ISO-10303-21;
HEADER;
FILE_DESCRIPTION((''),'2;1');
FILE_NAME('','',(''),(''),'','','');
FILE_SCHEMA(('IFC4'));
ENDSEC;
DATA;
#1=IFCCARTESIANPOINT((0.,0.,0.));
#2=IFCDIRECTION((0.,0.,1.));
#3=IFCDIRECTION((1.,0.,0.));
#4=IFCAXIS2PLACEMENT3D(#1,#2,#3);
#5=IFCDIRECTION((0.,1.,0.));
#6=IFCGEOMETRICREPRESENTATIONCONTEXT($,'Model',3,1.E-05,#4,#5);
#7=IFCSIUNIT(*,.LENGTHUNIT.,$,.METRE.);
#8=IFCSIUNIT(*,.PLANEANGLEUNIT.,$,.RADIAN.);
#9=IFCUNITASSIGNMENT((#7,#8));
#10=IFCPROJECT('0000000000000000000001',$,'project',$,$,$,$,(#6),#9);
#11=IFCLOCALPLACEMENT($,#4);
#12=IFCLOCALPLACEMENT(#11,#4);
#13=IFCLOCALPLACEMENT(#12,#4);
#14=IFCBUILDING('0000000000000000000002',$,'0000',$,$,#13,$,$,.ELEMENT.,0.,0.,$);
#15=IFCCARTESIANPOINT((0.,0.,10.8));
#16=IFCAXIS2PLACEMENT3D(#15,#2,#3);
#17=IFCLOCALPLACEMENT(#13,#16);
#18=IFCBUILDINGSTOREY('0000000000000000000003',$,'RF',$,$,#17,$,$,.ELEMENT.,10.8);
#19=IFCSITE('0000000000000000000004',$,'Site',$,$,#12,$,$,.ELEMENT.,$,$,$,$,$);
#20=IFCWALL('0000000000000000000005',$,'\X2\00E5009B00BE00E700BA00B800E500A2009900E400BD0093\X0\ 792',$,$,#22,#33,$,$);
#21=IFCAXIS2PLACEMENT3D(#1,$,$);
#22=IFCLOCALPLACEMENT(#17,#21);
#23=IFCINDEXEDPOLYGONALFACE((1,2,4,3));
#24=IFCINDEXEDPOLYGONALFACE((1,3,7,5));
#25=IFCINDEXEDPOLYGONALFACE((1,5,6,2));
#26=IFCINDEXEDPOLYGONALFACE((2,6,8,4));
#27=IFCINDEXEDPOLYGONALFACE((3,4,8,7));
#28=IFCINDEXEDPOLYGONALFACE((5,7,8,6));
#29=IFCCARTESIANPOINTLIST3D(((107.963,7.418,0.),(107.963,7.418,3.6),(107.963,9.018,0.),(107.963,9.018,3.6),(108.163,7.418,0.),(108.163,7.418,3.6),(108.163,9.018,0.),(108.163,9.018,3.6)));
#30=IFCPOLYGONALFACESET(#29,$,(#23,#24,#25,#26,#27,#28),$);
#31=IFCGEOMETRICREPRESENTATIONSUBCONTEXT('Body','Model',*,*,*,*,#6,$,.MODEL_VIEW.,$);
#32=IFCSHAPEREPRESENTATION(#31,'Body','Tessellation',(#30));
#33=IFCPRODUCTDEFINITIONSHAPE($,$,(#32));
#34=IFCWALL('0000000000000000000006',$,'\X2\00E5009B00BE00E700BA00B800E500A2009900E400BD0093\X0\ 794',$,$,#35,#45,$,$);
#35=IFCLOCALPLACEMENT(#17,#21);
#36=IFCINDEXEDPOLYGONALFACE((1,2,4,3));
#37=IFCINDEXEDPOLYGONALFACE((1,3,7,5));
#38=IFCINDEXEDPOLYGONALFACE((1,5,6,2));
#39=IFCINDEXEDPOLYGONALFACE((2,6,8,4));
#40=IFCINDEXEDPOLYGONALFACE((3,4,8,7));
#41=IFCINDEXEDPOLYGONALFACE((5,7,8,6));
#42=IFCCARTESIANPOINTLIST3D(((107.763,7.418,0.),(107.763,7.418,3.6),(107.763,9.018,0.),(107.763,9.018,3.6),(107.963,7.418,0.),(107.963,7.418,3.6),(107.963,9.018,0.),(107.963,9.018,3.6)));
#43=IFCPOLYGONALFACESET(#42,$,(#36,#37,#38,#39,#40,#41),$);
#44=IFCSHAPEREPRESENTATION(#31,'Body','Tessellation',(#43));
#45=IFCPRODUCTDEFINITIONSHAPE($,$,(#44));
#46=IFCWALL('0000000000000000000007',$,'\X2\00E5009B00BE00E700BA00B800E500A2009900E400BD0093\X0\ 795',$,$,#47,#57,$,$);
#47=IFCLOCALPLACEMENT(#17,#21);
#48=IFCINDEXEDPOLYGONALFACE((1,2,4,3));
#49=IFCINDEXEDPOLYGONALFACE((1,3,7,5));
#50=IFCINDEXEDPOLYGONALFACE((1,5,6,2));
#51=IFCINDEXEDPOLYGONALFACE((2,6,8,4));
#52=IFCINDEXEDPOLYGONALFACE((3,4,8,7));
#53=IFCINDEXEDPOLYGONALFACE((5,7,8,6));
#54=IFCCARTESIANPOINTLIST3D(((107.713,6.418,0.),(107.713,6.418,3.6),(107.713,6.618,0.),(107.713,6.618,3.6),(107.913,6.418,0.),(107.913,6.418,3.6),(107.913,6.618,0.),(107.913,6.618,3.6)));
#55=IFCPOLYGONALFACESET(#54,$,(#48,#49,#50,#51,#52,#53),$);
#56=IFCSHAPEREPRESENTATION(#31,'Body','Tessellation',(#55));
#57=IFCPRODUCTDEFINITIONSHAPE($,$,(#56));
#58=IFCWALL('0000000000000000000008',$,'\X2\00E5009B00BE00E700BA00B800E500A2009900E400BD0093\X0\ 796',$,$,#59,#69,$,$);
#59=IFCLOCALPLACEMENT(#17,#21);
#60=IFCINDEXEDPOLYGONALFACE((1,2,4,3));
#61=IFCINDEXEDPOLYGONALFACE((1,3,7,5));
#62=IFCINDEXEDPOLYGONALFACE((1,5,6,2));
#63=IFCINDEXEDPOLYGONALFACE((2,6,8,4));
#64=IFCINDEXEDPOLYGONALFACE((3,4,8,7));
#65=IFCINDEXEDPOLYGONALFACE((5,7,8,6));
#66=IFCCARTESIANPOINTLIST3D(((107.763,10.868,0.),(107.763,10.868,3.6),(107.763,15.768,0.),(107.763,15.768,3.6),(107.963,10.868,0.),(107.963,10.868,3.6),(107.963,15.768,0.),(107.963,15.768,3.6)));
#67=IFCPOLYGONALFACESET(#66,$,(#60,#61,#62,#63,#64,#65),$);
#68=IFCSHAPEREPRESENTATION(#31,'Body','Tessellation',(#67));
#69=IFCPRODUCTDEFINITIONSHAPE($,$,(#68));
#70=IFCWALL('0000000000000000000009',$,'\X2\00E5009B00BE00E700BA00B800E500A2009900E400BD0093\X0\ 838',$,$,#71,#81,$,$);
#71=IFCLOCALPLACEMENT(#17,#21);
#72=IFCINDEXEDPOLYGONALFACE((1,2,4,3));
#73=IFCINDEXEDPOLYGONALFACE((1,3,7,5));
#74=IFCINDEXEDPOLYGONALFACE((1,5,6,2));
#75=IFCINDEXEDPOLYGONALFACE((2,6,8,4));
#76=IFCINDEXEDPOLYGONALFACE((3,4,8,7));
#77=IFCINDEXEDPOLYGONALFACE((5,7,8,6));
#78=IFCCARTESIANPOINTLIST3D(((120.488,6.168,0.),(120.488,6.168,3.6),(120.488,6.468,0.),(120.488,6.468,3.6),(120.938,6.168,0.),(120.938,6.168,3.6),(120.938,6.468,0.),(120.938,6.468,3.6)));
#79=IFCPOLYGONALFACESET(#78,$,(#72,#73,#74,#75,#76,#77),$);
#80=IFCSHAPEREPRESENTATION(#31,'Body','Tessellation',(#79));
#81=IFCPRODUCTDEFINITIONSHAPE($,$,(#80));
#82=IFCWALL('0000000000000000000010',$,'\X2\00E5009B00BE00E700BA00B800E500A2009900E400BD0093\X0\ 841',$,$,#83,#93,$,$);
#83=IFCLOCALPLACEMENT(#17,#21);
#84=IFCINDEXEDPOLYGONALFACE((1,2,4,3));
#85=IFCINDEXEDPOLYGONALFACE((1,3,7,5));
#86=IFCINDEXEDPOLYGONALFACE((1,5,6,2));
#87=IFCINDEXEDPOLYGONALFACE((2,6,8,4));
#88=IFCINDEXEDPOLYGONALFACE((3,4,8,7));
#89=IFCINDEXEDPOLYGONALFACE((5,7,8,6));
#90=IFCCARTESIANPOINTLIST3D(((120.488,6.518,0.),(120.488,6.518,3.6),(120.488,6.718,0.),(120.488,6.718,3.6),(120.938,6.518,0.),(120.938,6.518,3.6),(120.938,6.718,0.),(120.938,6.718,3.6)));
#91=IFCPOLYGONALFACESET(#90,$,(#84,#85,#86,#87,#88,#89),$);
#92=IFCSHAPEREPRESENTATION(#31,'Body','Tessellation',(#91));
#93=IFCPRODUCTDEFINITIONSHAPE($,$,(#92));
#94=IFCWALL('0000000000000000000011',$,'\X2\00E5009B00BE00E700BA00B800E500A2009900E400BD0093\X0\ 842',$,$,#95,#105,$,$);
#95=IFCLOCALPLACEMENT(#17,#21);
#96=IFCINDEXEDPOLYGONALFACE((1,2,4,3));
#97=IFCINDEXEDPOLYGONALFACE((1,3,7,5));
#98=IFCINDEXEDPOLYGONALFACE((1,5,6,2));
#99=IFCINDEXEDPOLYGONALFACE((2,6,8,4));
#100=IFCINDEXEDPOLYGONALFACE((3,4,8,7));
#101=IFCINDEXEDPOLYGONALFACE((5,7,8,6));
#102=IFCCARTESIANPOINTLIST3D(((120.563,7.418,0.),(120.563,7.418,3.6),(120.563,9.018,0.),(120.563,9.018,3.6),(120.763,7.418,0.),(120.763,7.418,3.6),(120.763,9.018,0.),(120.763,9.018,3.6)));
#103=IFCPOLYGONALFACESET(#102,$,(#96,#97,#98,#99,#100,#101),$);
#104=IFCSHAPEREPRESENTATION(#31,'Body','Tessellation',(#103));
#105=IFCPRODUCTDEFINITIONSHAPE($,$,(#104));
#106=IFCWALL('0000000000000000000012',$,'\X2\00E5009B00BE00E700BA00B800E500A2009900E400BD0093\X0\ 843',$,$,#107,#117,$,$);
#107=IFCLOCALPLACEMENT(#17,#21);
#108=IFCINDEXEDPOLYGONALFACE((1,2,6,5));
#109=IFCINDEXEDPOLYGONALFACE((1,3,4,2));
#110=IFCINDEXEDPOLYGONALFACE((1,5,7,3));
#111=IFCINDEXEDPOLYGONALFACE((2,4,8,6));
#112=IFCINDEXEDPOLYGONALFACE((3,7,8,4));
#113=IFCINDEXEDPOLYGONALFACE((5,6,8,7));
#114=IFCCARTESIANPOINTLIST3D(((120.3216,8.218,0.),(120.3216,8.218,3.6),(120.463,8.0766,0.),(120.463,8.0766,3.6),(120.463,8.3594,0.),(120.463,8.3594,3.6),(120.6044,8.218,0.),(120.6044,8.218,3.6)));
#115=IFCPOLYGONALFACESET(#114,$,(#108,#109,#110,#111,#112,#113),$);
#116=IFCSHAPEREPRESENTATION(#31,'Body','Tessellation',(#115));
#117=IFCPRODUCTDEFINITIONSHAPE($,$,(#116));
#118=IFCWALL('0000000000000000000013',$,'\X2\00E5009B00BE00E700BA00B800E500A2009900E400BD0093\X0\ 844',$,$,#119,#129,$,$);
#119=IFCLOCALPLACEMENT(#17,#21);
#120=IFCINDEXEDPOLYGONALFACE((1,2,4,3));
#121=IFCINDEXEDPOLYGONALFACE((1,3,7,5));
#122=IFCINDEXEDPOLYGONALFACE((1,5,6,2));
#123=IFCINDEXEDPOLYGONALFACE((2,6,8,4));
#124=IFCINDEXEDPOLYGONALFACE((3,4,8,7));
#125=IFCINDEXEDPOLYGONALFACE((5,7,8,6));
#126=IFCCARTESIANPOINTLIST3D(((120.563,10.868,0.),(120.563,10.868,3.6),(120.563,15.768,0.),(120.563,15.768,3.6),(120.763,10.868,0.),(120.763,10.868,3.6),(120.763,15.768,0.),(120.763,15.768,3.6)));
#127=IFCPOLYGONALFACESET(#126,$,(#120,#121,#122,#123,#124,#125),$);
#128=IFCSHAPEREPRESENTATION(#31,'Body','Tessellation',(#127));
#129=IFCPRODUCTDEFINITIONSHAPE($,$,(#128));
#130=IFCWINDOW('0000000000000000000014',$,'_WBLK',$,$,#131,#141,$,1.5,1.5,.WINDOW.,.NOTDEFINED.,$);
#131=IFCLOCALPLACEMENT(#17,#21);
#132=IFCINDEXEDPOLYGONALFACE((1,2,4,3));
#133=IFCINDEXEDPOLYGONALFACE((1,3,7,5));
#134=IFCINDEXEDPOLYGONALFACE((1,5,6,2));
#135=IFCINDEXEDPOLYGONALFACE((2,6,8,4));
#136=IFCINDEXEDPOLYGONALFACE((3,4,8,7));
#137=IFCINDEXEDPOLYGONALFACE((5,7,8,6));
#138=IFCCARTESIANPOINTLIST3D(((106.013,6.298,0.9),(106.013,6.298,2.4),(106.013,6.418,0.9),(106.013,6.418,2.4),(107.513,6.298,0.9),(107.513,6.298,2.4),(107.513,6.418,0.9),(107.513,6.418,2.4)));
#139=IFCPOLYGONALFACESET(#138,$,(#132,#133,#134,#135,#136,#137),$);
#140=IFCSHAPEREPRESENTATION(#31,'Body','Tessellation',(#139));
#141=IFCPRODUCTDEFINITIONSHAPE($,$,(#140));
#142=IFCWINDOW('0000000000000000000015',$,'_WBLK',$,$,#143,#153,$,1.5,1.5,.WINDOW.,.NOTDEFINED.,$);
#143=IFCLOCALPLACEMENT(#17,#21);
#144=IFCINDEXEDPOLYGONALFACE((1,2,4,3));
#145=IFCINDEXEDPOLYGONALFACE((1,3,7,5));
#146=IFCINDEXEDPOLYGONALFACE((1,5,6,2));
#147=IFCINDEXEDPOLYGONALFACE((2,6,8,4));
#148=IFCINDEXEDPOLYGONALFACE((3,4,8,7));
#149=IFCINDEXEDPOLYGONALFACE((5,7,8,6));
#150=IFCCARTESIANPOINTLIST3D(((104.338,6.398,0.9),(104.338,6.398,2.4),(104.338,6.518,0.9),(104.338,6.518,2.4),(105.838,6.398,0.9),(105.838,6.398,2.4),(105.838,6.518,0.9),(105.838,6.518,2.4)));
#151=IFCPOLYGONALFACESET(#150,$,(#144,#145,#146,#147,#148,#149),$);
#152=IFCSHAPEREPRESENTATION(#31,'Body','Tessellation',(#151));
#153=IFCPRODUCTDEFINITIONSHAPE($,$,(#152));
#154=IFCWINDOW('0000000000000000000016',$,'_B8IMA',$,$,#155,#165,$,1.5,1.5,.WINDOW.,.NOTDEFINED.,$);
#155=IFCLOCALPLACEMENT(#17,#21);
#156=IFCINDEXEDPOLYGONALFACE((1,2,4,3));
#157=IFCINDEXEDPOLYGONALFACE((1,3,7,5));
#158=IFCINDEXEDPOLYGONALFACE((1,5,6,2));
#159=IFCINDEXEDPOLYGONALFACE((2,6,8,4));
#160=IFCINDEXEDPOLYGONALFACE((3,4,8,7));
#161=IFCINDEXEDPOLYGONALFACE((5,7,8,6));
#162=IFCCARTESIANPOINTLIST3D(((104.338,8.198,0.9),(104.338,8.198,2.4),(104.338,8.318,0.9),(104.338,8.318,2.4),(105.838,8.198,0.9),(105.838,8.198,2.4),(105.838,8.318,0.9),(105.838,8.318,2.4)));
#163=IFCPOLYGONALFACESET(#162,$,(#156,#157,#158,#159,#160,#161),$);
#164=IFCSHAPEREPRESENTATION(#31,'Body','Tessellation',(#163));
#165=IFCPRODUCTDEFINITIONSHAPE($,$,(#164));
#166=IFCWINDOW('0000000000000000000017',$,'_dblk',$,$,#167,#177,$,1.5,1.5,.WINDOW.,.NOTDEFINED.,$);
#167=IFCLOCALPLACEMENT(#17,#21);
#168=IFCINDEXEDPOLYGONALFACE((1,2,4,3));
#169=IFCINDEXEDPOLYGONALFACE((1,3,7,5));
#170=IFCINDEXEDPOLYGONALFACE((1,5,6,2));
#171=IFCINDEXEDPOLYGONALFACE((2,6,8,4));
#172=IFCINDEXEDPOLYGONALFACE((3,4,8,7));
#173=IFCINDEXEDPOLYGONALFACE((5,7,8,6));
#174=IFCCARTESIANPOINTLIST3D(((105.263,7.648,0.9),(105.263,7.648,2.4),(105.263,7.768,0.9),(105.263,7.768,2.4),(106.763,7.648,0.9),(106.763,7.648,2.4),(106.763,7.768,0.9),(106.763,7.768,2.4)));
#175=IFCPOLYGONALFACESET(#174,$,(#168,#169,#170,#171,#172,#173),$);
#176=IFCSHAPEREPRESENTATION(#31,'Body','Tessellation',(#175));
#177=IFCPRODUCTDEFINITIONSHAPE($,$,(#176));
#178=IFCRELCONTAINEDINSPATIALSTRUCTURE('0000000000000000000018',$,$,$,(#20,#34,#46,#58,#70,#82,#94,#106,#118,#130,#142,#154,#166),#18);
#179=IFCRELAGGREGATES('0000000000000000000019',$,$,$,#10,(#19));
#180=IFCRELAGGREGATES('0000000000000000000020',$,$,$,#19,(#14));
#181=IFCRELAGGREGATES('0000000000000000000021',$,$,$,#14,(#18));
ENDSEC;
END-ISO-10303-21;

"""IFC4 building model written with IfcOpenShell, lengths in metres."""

from ifc_helpers import new_model, si_unit, direction, frame, frame_2d, origin_with_axes, place, context, subcontext, project, spatial, rectangle, extrude, element, save


model = new_model("IFC4")

# Units and contexts
model_context = context("Model", 3, precision=1e-05, world=origin_with_axes(), true_north=direction((0.0, 1.0, 0.0)))
body_context = subcontext(model_context, "Body", "Model", "MODEL_VIEW")
ifc_project = project(units=[si_unit("LENGTHUNIT", "METRE"), si_unit("PLANEANGLEUNIT", "RADIAN")], contexts=[model_context])

# Site, building, storey
placement = place(None, origin_with_axes())
site_placement = place(placement, origin_with_axes())
site = spatial("IfcSite", under=ifc_project, at=site_placement, Name="Site", CompositionType="ELEMENT")
building_placement = place(site_placement, origin_with_axes())
building = spatial("IfcBuilding", under=site, at=building_placement, Name="0000", CompositionType="ELEMENT", ElevationOfRefHeight=0.0, ElevationOfTerrain=0.0)
storey_placement = place(building_placement, frame((0.0, 0.0, 10.8), z_axis=(0.0, 0.0, 1.0), x_axis=(1.0, 0.0, 0.0)))
storey = spatial("IfcBuildingStorey", under=building, at=storey_placement, Name="RF", CompositionType="ELEMENT", Elevation=10.8)

# Walls
for number, where, z_axis, x_axis, name in (
    (1, (108.063, 8.218, 0.0), (0.0, 0.0, 1.0), (0.0, -1.0, 0.0), "å\u009b¾çº¸å¢\u0099ä½\u0093 792"),
    (2, (107.863, 8.218, 0.0), (0.0, 0.0, 1.0), (0.0, -1.0, 0.0), "å\u009b¾çº¸å¢\u0099ä½\u0093 794"),
):
    element("IfcWall", number, at=place(storey_placement, frame(where, z_axis=z_axis, x_axis=x_axis)), inside=storey, Name=name, context=body_context, shape_type="SweptSolid", body=[
        extrude(rectangle(XDim=1.6, YDim=0.2, at=frame_2d((0.0, 0.0), x_axis=(1.0, 0.0, 0.0))), frame((0.0, 0.0, 0.0), z_axis=(0.0, 0.0, 1.0)), (0.0, 0.0, 1.0), 3.6),
    ])
wall_1_placement = place(storey_placement, frame((107.813, 6.518, 0.0), z_axis=(0.0, 0.0, 1.0), x_axis=(0.0, -1.0, 0.0)))
element("IfcWall", 3, at=wall_1_placement, inside=storey, Name="å\u009b¾çº¸å¢\u0099ä½\u0093 795", context=body_context, shape_type="SweptSolid", body=[
    extrude(rectangle(XDim=0.2, YDim=0.2, at=frame_2d((0.0, 0.0), x_axis=(1.0, 0.0, 0.0))), frame((0.0, 0.0, 0.0), z_axis=(0.0, 0.0, 1.0)), (0.0, 0.0, 1.0), 3.6),
])
wall_2_placement = place(storey_placement, frame((107.863, 13.318, 0.0), z_axis=(0.0, 0.0, 1.0), x_axis=(0.0, -1.0, 0.0)))
element("IfcWall", 4, at=wall_2_placement, inside=storey, Name="å\u009b¾çº¸å¢\u0099ä½\u0093 796", context=body_context, shape_type="SweptSolid", body=[
    extrude(rectangle(XDim=4.9, YDim=0.2, at=frame_2d((0.0, 0.0), x_axis=(1.0, 0.0, 0.0))), frame((0.0, 0.0, 0.0), z_axis=(0.0, 0.0, 1.0)), (0.0, 0.0, 1.0), 3.6),
])
wall_3_placement = place(storey_placement, frame((120.713, 6.318, 0.0), z_axis=(0.0, 0.0, 1.0), x_axis=(1.0, 0.0, 0.0)))
element("IfcWall", 5, at=wall_3_placement, inside=storey, Name="å\u009b¾çº¸å¢\u0099ä½\u0093 838", context=body_context, shape_type="SweptSolid", body=[
    extrude(rectangle(XDim=0.45, YDim=0.3, at=frame_2d((0.0, 0.0), x_axis=(1.0, 0.0, 0.0))), frame((0.0, 0.0, 0.0), z_axis=(0.0, 0.0, 1.0)), (0.0, 0.0, 1.0), 3.6),
])
wall_4_placement = place(storey_placement, frame((120.713, 6.618, 0.0), z_axis=(0.0, 0.0, 1.0), x_axis=(1.0, 0.0, 0.0)))
element("IfcWall", 6, at=wall_4_placement, inside=storey, Name="å\u009b¾çº¸å¢\u0099ä½\u0093 841", context=body_context, shape_type="SweptSolid", body=[
    extrude(rectangle(XDim=0.45, YDim=0.2, at=frame_2d((0.0, 0.0), x_axis=(1.0, 0.0, 0.0))), frame((0.0, 0.0, 0.0), z_axis=(0.0, 0.0, 1.0)), (0.0, 0.0, 1.0), 3.6),
])
wall_5_placement = place(storey_placement, frame((120.663, 8.218, 0.0), z_axis=(0.0, 0.0, 1.0), x_axis=(0.0, -1.0, 0.0)))
element("IfcWall", 7, at=wall_5_placement, inside=storey, Name="å\u009b¾çº¸å¢\u0099ä½\u0093 842", context=body_context, shape_type="SweptSolid", body=[
    extrude(rectangle(XDim=1.6, YDim=0.2, at=frame_2d((0.0, 0.0), x_axis=(1.0, 0.0, 0.0))), frame((0.0, 0.0, 0.0), z_axis=(0.0, 0.0, 1.0)), (0.0, 0.0, 1.0), 3.6),
])
wall_6_placement = place(storey_placement, frame((120.463, 8.218, 0.0), z_axis=(0.0, 0.0, 1.0), x_axis=(0.707107, -0.707107, 0.0)))
element("IfcWall", 8, at=wall_6_placement, inside=storey, Name="å\u009b¾çº¸å¢\u0099ä½\u0093 843", context=body_context, shape_type="SweptSolid", body=[
    extrude(rectangle(XDim=0.2, YDim=0.2, at=frame_2d((0.0, 0.0), x_axis=(1.0, 0.0, 0.0))), frame((0.0, 0.0, 0.0), z_axis=(0.0, 0.0, 1.0)), (0.0, 0.0, 1.0), 3.6),
])
wall_7_placement = place(storey_placement, frame((120.663, 13.318, 0.0), z_axis=(0.0, 0.0, 1.0), x_axis=(0.0, -1.0, 0.0)))
element("IfcWall", 9, at=wall_7_placement, inside=storey, Name="å\u009b¾çº¸å¢\u0099ä½\u0093 844", context=body_context, shape_type="SweptSolid", body=[
    extrude(rectangle(XDim=4.9, YDim=0.2, at=frame_2d((0.0, 0.0), x_axis=(1.0, 0.0, 0.0))), frame((0.0, 0.0, 0.0), z_axis=(0.0, 0.0, 1.0)), (0.0, 0.0, 1.0), 3.6),
])

# Windows
for number, where, z_axis, x_axis, name in (
    (10, (106.763, 6.358, 0.9), (0.0, 0.0, 1.0), (1.0, 0.0, 0.0), "_WBLK"),
    (11, (105.088, 6.458, 0.9), (0.0, 0.0, 1.0), (1.0, 0.0, 0.0), "_WBLK"),
    (12, (105.088, 8.258, 0.9), (0.0, 0.0, 1.0), (1.0, 0.0, 0.0), "_B8IMA"),
    (13, (106.013, 7.708, 0.9), (0.0, 0.0, 1.0), (1.0, 0.0, 0.0), "_dblk"),
):
    element("IfcWindow", number, at=place(storey_placement, frame(where, z_axis=z_axis, x_axis=x_axis)), inside=storey, Name=name, OverallHeight=1.5, OverallWidth=1.5, PartitioningType="NOTDEFINED", PredefinedType="WINDOW", context=body_context, shape_type="SweptSolid", body=[
        extrude(rectangle(XDim=1.5, YDim=0.12, at=frame_2d((0.0, 0.0), x_axis=(1.0, 0.0, 0.0))), frame((0.0, 0.0, 0.0), z_axis=(0.0, 0.0, 1.0)), (0.0, 0.0, 1.0), 1.5),
    ])

save(model, "model.ifc")
